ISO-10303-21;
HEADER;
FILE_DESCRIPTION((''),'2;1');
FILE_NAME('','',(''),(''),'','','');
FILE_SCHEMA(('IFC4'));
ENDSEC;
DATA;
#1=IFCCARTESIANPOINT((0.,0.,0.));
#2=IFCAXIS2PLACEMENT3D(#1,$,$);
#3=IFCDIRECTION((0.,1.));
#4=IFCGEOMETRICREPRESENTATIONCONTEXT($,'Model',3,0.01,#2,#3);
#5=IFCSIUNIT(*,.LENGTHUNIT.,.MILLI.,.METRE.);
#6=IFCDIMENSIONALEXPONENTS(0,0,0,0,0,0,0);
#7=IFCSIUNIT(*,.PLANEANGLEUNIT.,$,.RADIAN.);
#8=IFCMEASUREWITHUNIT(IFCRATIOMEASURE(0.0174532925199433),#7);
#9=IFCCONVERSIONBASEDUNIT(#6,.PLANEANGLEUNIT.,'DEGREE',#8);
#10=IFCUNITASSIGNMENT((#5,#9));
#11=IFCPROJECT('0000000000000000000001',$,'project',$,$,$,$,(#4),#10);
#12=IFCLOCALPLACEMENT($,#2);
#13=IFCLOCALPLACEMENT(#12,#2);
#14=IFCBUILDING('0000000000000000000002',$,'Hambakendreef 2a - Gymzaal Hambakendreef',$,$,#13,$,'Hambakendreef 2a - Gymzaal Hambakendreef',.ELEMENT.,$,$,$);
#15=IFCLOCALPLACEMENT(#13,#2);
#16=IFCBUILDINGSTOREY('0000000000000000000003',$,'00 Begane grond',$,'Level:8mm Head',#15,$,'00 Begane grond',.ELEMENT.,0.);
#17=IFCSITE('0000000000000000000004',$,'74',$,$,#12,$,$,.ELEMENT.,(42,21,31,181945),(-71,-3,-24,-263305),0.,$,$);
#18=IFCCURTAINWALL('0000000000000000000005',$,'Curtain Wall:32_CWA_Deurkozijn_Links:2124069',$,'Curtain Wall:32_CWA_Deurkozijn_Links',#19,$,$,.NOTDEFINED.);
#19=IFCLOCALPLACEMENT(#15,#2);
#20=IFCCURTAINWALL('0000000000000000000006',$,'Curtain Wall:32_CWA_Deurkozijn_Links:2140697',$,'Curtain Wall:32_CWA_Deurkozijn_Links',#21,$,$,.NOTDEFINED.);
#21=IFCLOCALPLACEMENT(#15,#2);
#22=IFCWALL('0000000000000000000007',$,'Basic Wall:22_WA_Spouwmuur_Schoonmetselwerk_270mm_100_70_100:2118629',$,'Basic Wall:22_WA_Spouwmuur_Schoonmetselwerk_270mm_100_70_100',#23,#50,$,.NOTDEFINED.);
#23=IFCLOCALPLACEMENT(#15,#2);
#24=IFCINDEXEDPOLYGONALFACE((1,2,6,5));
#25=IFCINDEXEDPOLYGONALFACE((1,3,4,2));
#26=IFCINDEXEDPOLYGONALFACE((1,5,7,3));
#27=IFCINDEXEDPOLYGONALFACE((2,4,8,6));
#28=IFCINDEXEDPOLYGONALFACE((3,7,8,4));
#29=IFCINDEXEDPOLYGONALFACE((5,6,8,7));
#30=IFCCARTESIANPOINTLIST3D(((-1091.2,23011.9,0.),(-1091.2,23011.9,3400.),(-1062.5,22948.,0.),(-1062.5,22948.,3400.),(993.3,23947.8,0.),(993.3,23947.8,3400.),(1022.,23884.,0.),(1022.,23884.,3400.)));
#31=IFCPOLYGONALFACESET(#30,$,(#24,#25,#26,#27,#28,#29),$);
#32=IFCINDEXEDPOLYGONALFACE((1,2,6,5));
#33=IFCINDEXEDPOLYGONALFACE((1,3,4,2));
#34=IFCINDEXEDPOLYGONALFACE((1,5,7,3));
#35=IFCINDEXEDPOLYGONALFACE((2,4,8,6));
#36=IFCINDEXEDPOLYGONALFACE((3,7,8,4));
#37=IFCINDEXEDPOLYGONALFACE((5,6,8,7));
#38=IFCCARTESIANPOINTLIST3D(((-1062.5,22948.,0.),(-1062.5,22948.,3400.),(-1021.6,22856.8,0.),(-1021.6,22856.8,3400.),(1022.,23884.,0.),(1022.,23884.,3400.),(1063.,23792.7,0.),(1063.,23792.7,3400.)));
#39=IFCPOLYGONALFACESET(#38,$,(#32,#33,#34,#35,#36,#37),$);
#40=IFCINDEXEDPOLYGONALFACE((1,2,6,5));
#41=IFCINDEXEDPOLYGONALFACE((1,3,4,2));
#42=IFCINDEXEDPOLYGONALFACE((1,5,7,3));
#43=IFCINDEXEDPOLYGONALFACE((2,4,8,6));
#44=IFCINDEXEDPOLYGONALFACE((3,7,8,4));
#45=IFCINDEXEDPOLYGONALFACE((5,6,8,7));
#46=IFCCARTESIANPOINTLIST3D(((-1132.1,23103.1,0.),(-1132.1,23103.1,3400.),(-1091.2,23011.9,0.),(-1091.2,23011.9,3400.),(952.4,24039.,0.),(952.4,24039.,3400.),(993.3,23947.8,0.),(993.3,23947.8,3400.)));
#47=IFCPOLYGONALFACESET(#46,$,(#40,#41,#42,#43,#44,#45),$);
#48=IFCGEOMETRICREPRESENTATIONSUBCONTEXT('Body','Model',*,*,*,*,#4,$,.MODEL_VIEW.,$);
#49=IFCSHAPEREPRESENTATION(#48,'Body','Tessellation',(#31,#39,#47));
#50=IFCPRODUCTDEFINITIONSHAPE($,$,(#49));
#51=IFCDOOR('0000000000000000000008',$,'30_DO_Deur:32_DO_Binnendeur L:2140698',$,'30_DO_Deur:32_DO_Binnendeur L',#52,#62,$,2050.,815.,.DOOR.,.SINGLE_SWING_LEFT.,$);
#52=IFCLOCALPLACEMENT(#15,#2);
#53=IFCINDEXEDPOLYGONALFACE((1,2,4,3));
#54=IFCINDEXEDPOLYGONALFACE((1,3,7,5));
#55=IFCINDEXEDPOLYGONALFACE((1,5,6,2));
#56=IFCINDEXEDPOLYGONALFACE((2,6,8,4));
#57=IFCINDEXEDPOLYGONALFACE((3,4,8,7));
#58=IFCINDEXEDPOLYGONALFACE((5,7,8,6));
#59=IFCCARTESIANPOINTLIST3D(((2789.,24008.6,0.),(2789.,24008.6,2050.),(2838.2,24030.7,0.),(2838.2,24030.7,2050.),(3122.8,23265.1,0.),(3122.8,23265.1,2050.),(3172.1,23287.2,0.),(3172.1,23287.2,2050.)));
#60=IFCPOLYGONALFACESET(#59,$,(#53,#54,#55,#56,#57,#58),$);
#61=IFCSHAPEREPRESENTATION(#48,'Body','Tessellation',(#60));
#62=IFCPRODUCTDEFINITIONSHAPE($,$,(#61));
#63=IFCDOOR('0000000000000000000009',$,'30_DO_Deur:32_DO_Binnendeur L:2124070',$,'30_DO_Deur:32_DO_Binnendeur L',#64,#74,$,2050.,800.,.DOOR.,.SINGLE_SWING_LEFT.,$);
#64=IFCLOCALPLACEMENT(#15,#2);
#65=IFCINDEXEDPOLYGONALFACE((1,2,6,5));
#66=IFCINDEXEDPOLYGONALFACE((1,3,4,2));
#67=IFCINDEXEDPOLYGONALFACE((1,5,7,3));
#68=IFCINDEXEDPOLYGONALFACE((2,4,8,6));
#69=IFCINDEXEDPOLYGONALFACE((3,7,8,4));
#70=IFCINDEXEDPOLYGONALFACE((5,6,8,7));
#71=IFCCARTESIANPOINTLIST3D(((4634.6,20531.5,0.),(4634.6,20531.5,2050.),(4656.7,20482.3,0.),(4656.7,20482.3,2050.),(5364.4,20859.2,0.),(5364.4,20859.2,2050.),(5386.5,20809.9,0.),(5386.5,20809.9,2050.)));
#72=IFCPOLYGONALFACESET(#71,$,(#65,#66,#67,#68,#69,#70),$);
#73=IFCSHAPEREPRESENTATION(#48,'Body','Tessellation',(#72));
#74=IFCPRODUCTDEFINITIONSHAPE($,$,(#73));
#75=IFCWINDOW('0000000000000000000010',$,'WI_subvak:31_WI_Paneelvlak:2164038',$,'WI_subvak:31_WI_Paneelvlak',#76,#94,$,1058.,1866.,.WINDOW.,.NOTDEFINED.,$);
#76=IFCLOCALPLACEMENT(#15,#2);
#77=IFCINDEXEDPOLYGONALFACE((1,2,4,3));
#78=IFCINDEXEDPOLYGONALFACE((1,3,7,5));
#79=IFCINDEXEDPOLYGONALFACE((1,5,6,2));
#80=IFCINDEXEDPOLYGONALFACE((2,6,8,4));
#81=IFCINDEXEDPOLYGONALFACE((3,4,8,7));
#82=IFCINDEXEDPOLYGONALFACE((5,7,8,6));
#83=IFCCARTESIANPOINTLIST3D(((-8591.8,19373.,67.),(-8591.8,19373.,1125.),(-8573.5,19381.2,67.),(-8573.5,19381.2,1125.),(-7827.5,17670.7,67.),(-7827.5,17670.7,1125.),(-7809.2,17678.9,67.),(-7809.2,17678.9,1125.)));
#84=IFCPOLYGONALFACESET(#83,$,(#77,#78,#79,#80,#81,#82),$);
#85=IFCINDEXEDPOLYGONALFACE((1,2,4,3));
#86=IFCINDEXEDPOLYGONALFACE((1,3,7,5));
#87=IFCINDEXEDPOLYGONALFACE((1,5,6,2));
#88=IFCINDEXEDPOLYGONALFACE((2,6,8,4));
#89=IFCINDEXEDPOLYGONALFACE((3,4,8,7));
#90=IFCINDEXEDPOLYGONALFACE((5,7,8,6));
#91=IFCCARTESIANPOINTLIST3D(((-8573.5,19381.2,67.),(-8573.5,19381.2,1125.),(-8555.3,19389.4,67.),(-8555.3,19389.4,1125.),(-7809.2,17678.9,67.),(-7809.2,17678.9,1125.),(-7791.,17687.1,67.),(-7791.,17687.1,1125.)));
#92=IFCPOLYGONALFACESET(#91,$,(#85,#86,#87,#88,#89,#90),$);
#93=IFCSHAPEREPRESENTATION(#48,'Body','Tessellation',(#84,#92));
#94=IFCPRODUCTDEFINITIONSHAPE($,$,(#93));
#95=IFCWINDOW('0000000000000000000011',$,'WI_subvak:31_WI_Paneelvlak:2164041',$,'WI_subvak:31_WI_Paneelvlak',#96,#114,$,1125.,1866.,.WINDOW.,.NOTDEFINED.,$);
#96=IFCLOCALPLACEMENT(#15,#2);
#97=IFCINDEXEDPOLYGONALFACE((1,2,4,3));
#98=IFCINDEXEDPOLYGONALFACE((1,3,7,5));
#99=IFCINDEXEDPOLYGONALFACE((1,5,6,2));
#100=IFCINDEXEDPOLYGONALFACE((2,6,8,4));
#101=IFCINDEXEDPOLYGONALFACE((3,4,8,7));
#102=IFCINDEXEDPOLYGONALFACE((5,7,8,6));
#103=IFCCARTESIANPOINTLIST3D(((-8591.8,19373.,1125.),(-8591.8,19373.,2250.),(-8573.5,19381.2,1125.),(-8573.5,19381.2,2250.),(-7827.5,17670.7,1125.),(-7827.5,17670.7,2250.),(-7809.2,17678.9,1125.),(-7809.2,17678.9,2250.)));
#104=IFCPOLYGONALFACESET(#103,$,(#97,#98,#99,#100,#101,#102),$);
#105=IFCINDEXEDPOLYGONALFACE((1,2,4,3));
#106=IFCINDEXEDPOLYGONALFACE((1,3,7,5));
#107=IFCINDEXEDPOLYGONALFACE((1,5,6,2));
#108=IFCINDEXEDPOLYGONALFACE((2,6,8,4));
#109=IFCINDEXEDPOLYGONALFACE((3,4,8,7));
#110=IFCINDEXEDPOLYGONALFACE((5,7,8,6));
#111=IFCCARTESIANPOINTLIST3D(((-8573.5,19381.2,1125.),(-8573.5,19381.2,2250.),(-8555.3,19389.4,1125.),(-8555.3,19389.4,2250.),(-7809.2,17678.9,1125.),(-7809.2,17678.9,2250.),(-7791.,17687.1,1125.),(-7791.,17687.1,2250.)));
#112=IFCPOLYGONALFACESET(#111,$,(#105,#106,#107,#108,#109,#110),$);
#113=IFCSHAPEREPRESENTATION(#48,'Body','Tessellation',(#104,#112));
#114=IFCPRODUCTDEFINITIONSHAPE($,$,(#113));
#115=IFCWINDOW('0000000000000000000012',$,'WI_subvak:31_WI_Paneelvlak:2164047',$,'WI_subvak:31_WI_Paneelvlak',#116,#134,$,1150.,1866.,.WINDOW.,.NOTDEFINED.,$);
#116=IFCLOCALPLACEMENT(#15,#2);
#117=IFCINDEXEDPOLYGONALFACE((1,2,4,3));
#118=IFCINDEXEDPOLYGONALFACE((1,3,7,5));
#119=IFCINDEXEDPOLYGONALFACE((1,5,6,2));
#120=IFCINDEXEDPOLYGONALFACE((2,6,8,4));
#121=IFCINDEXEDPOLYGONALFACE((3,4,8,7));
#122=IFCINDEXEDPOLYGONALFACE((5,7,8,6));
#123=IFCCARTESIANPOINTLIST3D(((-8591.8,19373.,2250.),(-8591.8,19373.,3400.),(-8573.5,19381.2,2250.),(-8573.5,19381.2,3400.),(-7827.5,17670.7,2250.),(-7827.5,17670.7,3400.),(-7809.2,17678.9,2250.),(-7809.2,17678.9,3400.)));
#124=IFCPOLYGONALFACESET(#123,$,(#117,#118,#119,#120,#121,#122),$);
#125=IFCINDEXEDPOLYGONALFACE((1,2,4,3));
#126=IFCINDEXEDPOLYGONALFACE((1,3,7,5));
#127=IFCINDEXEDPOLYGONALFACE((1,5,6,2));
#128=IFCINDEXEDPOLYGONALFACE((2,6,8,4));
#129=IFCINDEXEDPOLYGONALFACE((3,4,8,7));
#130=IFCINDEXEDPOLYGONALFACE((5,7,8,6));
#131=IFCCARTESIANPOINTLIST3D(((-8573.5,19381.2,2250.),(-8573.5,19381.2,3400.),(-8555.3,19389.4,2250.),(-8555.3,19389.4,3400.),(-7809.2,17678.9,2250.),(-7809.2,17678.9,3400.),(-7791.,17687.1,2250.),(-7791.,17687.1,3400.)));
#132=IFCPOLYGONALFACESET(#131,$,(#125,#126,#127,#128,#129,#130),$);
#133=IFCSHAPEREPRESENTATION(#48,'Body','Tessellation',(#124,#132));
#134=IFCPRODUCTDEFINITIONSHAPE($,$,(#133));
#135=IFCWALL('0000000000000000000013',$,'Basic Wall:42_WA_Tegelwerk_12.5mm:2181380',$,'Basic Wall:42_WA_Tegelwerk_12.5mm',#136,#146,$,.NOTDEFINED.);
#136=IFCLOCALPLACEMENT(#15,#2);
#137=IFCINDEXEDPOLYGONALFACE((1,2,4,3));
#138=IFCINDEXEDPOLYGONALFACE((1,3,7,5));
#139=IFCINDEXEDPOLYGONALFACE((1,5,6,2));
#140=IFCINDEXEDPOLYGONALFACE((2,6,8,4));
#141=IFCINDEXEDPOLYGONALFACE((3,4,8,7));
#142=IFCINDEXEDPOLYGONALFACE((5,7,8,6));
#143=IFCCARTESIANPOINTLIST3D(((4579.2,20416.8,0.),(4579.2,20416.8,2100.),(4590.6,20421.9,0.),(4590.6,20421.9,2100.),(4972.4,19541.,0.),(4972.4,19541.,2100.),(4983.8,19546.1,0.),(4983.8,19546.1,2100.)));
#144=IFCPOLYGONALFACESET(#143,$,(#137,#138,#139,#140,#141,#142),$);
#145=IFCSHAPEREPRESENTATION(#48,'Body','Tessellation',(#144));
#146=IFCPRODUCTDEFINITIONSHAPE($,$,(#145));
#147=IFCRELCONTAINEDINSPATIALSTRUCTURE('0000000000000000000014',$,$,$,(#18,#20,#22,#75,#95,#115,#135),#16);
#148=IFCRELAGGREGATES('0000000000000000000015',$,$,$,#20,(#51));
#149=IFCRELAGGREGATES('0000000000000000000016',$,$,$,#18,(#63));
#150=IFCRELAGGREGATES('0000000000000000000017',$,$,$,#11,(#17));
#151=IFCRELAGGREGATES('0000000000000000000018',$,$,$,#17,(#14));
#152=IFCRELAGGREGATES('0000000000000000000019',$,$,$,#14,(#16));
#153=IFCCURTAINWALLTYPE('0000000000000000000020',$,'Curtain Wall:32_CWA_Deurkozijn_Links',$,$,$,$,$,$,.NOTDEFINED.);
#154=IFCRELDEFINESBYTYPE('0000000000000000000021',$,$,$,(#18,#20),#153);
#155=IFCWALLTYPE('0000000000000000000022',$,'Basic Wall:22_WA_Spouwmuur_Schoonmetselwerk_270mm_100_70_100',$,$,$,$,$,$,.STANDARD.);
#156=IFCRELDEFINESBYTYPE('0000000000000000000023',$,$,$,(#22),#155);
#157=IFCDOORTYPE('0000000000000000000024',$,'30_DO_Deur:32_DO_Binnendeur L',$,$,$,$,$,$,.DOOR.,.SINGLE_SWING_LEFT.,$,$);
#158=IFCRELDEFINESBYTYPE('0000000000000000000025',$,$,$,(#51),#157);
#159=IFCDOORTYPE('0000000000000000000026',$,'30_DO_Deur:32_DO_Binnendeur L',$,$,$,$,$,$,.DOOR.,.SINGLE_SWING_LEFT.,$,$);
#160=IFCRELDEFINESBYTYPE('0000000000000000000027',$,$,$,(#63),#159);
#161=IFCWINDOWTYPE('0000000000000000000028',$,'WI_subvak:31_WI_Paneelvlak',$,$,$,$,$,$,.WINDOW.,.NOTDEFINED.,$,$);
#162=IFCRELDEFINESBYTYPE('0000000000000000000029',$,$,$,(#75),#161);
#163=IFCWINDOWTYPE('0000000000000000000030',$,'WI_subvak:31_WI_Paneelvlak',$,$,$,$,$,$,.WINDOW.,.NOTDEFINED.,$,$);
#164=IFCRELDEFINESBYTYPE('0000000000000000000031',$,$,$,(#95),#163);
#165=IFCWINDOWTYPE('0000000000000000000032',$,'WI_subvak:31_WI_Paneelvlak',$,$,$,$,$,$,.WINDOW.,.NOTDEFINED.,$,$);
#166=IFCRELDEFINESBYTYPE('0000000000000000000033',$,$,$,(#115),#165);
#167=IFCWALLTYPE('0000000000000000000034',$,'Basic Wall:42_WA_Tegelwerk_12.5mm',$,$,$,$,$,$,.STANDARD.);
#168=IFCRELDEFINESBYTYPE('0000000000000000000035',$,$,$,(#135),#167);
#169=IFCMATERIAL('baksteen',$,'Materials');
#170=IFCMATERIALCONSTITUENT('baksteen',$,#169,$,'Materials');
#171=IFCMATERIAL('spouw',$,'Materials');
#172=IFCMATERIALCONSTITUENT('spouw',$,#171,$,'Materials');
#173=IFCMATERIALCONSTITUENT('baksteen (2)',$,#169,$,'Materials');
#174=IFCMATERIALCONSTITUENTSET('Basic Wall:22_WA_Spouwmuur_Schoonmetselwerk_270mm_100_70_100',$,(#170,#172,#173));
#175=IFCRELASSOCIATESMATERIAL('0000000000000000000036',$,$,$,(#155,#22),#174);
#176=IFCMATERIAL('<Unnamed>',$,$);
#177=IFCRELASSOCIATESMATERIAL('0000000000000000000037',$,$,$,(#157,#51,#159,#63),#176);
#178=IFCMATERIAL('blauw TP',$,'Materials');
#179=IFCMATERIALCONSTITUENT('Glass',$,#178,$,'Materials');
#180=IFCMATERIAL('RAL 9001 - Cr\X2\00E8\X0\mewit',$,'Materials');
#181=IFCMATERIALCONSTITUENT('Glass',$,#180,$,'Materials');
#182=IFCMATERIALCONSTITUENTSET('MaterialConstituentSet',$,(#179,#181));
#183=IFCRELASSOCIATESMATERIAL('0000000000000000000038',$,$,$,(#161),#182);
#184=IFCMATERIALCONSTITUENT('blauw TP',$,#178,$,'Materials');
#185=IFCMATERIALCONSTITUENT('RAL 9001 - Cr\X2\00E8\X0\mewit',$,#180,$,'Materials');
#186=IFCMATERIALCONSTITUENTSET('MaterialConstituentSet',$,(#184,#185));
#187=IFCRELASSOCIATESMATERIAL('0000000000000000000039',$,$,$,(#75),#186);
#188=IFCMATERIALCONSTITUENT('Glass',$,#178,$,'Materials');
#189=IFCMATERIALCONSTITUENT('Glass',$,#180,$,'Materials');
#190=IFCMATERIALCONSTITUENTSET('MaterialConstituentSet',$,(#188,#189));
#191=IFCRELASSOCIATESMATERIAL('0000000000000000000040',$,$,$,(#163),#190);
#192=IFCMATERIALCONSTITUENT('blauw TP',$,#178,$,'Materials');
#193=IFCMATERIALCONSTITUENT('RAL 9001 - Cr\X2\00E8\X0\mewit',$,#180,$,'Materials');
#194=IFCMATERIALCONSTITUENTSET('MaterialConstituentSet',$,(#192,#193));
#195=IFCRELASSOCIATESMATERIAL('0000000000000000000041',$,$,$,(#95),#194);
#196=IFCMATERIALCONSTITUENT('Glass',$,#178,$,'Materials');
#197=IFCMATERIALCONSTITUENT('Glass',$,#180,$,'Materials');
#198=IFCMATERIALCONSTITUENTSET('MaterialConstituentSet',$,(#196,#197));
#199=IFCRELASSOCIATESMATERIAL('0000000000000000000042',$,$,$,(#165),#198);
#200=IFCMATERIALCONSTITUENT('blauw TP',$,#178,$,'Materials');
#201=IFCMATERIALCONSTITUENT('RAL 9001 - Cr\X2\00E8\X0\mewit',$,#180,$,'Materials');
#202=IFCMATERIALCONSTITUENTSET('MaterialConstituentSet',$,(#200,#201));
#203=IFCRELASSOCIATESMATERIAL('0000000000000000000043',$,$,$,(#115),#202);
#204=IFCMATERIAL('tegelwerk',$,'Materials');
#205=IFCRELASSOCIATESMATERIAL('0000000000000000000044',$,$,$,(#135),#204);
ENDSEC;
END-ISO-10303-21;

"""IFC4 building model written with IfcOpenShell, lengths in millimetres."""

from ifc_helpers import new_model, entity, si_unit, converted_unit, direction, frame, origin, place, context, subcontext, project, spatial, indexed_curve, outline, extrude, source, transform, mapped, material, constituent, constituent_set, type_object, type_shapes, element, aggregate, save


model = new_model("IFC4")

# Units and contexts
model_context = context("Model", 3, precision=0.01, world=origin(), true_north=direction((0.0, 1.0)))
body_context = subcontext(model_context, "Body", "Model", "MODEL_VIEW")
ifc_project = project(units=[si_unit("LENGTHUNIT", "METRE", prefix="MILLI"), converted_unit("PLANEANGLEUNIT", "DEGREE", entity("IfcRatioMeasure", 0.0174532925199433), si_unit("PLANEANGLEUNIT", "RADIAN"), dimensions=[0, 0, 0, 0, 0, 0, 0])], contexts=[model_context])

# Site, building, storey
site_placement = place(None, origin())
site = spatial("IfcSite", under=ifc_project, at=site_placement, Name="74", CompositionType="ELEMENT", RefLatitude=(42, 21, 31, 181945), RefLongitude=(-71, -3, -24, -263305), RefElevation=0.0)
building_placement = place(site_placement, origin())
building = spatial("IfcBuilding", under=site, at=building_placement, Name="Hambakendreef 2a - Gymzaal Hambakendreef", LongName="Hambakendreef 2a - Gymzaal Hambakendreef", CompositionType="ELEMENT")
storey_placement = place(building_placement, origin())
storey = spatial("IfcBuildingStorey", under=building, at=storey_placement, Name="00 Begane grond", ObjectType="Level:8mm Head", LongName="00 Begane grond", CompositionType="ELEMENT", Elevation=0.0)

# Shared definitions
ifc_material_1 = material(Name="<Unnamed>")

# Curtain walls
curtain_wall_type_1 = type_object("IfcCurtainWallType", Name="Curtain Wall:32_CWA_Deurkozijn_Links", PredefinedType="NOTDEFINED")
curtain_wall_1_placement = place(storey_placement, origin())
curtain_wall_1 = element("IfcCurtainWall", 1, at=curtain_wall_1_placement, inside=storey, type_object=curtain_wall_type_1, Name="Curtain Wall:32_CWA_Deurkozijn_Links:2124069", ObjectType="Curtain Wall:32_CWA_Deurkozijn_Links", PredefinedType="NOTDEFINED")
curtain_wall_2_placement = place(storey_placement, origin())
curtain_wall_2 = element("IfcCurtainWall", 2, at=curtain_wall_2_placement, inside=storey, type_object=curtain_wall_type_1, Name="Curtain Wall:32_CWA_Deurkozijn_Links:2140697", ObjectType="Curtain Wall:32_CWA_Deurkozijn_Links", PredefinedType="NOTDEFINED")

# Shared definitions
ifc_material_2 = material(Name="baksteen", Category="Materials")
ifc_material_3 = material(Name="spouw", Category="Materials")

# Wall, opening
ifc_constituent_1 = constituent(ifc_material_2, Name="baksteen", Category="Materials")
ifc_constituent_2 = constituent(ifc_material_3, Name="spouw", Category="Materials")
ifc_constituent_3 = constituent(ifc_material_2, Name="baksteen (2)", Category="Materials")
ifc_constituent_set_1 = constituent_set(constituents=[ifc_constituent_1, ifc_constituent_2, ifc_constituent_3], Name="Basic Wall:22_WA_Spouwmuur_Schoonmetselwerk_270mm_100_70_100")
wall_type_1 = type_object("IfcWallType", Name="Basic Wall:22_WA_Spouwmuur_Schoonmetselwerk_270mm_100_70_100", PredefinedType="STANDARD", material=ifc_constituent_set_1)
wall_1_placement = place(storey_placement, frame((-1076.9, 22980.0, 0.0), z_axis=(0.0, 0.0, 1.0), x_axis=(0.91227, 0.40959, 0.0)))
wall_1 = element("IfcWall", 3, at=wall_1_placement, inside=storey, type_object=wall_type_1, material=ifc_constituent_set_1, Name="Basic Wall:22_WA_Spouwmuur_Schoonmetselwerk_270mm_100_70_100:2118629", ObjectType="Basic Wall:22_WA_Spouwmuur_Schoonmetselwerk_270mm_100_70_100", PredefinedType="NOTDEFINED", context=body_context, shape_type="SweptSolid", body=[
    extrude(outline(indexed_curve([(-1142.5, -35.0), (1142.5, -35.0), (1142.5, 35.0), (-1142.5, 35.0), (-1142.5, -35.0)], self_intersect=False)), frame((1142.5, 0.0, 0.0)), (0.0, 0.0, 1.0), 3400.0),
    extrude(outline(indexed_curve([(-50.0, -1142.5), (50.0, -1142.5), (50.0, 1142.5), (-50.0, 1142.5), (-50.0, -1142.5)], self_intersect=False)), frame((1142.5, -85.0, 0.0), z_axis=(0.0, 0.0, 1.0), x_axis=(0.0, 1.0, 0.0)), (0.0, 0.0, 1.0), 3400.0),
    extrude(outline(indexed_curve([(-50.0, -1142.5), (50.0, -1142.5), (50.0, 1142.5), (-50.0, 1142.5), (-50.0, -1142.5)], self_intersect=False)), frame((1142.5, 85.0, 0.0), z_axis=(0.0, 0.0, 1.0), x_axis=(0.0, -1.0, 0.0)), (0.0, 0.0, 1.0), 3400.0),
])
opening_1_placement = place(wall_1_placement, origin())
element("IfcOpeningElement", 4, at=opening_1_placement, cuts=wall_1, PredefinedType="OPENING", context=body_context, shape_type="SweptSolid", body=[
    extrude(outline(indexed_curve([(-1050.0, -457.5), (1050.0, -457.5), (1050.0, 457.5), (-1050.0, 457.5), (-1050.0, -457.5)], self_intersect=False)), frame((2980.8, -287.4, 1050.0), z_axis=(0.0, 1.0, 0.0), x_axis=(0.0, 0.0, 1.0)), (0.0, 0.0, 1.0), 574.8),
])

# Doors
door_type_1 = type_object("IfcDoorType", Name="30_DO_Deur:32_DO_Binnendeur L", OperationType="SINGLE_SWING_LEFT", PredefinedType="DOOR", material=ifc_material_1)
shared_shape_1 = source(origin(), body_context, "Body", "SweptSolid", [
    extrude(outline(indexed_curve([(-27.0, -407.5), (27.0, -407.5), (27.0, 407.5), (-27.0, 407.5), (-27.0, -407.5)], self_intersect=False)), frame((0.0, 0.0, 0.0), z_axis=(0.0, 0.0, 1.0), x_axis=(0.0, 1.0, 0.0)), (0.0, 0.0, 1.0), 2050.0),
])
type_shapes(door_type_1, [shared_shape_1])
door_1_placement = place(curtain_wall_2_placement, frame((2980.5, 23647.9, 0.0), z_axis=(0.0, 0.0, 1.0), x_axis=(0.40959, -0.91227, 0.0)))
door_1 = element("IfcDoor", 5, at=door_1_placement, type_object=door_type_1, material=ifc_material_1, Name="30_DO_Deur:32_DO_Binnendeur L:2140698", ObjectType="30_DO_Deur:32_DO_Binnendeur L", OperationType="SINGLE_SWING_LEFT", OverallHeight=2050.0, OverallWidth=815.0, PredefinedType="DOOR", context=body_context, shape_type="MappedRepresentation", body=[
    mapped(shared_shape_1, transform((0.0, 0.0, 0.0), scale=1.0)),
])
aggregate(curtain_wall_2, [door_1])
door_type_2 = type_object("IfcDoorType", Name="30_DO_Deur:32_DO_Binnendeur L", OperationType="SINGLE_SWING_LEFT", PredefinedType="DOOR", material=ifc_material_1)
shared_shape_2 = source(origin(), body_context, "Body", "SweptSolid", [
    extrude(outline(indexed_curve([(-27.0, -400.0), (27.0, -400.0), (27.0, 400.0), (-27.0, 400.0), (-27.0, -400.0)], self_intersect=False)), frame((0.0, 0.0, 0.0), z_axis=(0.0, 0.0, 1.0), x_axis=(0.0, 1.0, 0.0)), (0.0, 0.0, 1.0), 2050.0),
])
type_shapes(door_type_2, [shared_shape_2])
door_2_placement = place(curtain_wall_1_placement, frame((5010.5, 20670.7, 0.0), z_axis=(0.0, 0.0, 1.0), x_axis=(0.91227, 0.40959, 0.0)))
door_2 = element("IfcDoor", 6, at=door_2_placement, type_object=door_type_2, material=ifc_material_1, Name="30_DO_Deur:32_DO_Binnendeur L:2124070", ObjectType="30_DO_Deur:32_DO_Binnendeur L", OperationType="SINGLE_SWING_LEFT", OverallHeight=2050.0, OverallWidth=800.0, PredefinedType="DOOR", context=body_context, shape_type="MappedRepresentation", body=[
    mapped(shared_shape_2, transform((0.0, 0.0, 0.0), scale=1.0)),
])
aggregate(curtain_wall_1, [door_2])

# Windows
ifc_material_4 = material(Name="blauw TP", Category="Materials")
ifc_constituent_4 = constituent(ifc_material_4, Name="blauw TP", Category="Materials")
ifc_material_5 = material(Name="RAL 9001 - Crèmewit", Category="Materials")
ifc_constituent_5 = constituent(ifc_material_5, Name="RAL 9001 - Crèmewit", Category="Materials")
ifc_constituent_set_2 = constituent_set(constituents=[ifc_constituent_4, ifc_constituent_5], Name="MaterialConstituentSet")
ifc_constituent_6 = constituent(ifc_material_4, Name="Glass", Category="Materials")
ifc_constituent_7 = constituent(ifc_material_5, Name="Glass", Category="Materials")
ifc_constituent_set_3 = constituent_set(constituents=[ifc_constituent_6, ifc_constituent_7], Name="MaterialConstituentSet")
window_type_1 = type_object("IfcWindowType", Name="WI_subvak:31_WI_Paneelvlak", PartitioningType="NOTDEFINED", PredefinedType="WINDOW", material=ifc_constituent_set_3)
shared_shape_3 = source(origin(), body_context, "Body", "SweptSolid", [
    extrude(outline(indexed_curve([(-10.0, -933.0), (10.0, -933.0), (10.0, 933.0), (-10.0, 933.0), (-10.0, -933.0)], self_intersect=False)), frame((0.0, 10.0, 0.0), z_axis=(0.0, 0.0, 1.0), x_axis=(0.0, -1.0, 0.0)), (0.0, 0.0, 1.0), 1058.0),
    extrude(outline(indexed_curve([(-10.0, -933.0), (10.0, -933.0), (10.0, 933.0), (-10.0, 933.0), (-10.0, -933.0)], self_intersect=False)), frame((0.0, -10.0, 0.0), z_axis=(0.0, 0.0, 1.0), x_axis=(0.0, -1.0, 0.0)), (0.0, 0.0, 1.0), 1058.0),
])
type_shapes(window_type_1, [shared_shape_3])
window_1_placement = place(storey_placement, frame((-8191.4, 18530.0, 67.0), z_axis=(0.0, 0.0, 1.0), x_axis=(-0.40959, 0.91227, 0.0)))
element("IfcWindow", 7, at=window_1_placement, inside=storey, type_object=window_type_1, material=ifc_constituent_set_2, Name="WI_subvak:31_WI_Paneelvlak:2164038", ObjectType="WI_subvak:31_WI_Paneelvlak", OverallHeight=1058.0, OverallWidth=1866.0, PartitioningType="NOTDEFINED", PredefinedType="WINDOW", context=body_context, shape_type="MappedRepresentation", body=[
    mapped(shared_shape_3, transform((0.0, 0.0, 0.0), scale=1.0)),
])
ifc_constituent_8 = constituent(ifc_material_4, Name="blauw TP", Category="Materials")
ifc_constituent_9 = constituent(ifc_material_5, Name="RAL 9001 - Crèmewit", Category="Materials")
ifc_constituent_set_4 = constituent_set(constituents=[ifc_constituent_8, ifc_constituent_9], Name="MaterialConstituentSet")
ifc_constituent_10 = constituent(ifc_material_4, Name="Glass", Category="Materials")
ifc_constituent_11 = constituent(ifc_material_5, Name="Glass", Category="Materials")
ifc_constituent_set_5 = constituent_set(constituents=[ifc_constituent_10, ifc_constituent_11], Name="MaterialConstituentSet")
window_type_2 = type_object("IfcWindowType", Name="WI_subvak:31_WI_Paneelvlak", PartitioningType="NOTDEFINED", PredefinedType="WINDOW", material=ifc_constituent_set_5)
shared_shape_4 = source(origin(), body_context, "Body", "SweptSolid", [
    extrude(outline(indexed_curve([(-10.0, -933.0), (10.0, -933.0), (10.0, 933.0), (-10.0, 933.0), (-10.0, -933.0)], self_intersect=False)), frame((0.0, 10.0, 0.0), z_axis=(0.0, 0.0, 1.0), x_axis=(0.0, -1.0, 0.0)), (0.0, 0.0, 1.0), 1125.0),
    extrude(outline(indexed_curve([(-10.0, -933.0), (10.0, -933.0), (10.0, 933.0), (-10.0, 933.0), (-10.0, -933.0)], self_intersect=False)), frame((0.0, -10.0, 0.0), z_axis=(0.0, 0.0, 1.0), x_axis=(0.0, -1.0, 0.0)), (0.0, 0.0, 1.0), 1125.0),
])
type_shapes(window_type_2, [shared_shape_4])
window_2_placement = place(storey_placement, frame((-8191.4, 18530.0, 1125.0), z_axis=(0.0, 0.0, 1.0), x_axis=(-0.40959, 0.91227, 0.0)))
element("IfcWindow", 8, at=window_2_placement, inside=storey, type_object=window_type_2, material=ifc_constituent_set_4, Name="WI_subvak:31_WI_Paneelvlak:2164041", ObjectType="WI_subvak:31_WI_Paneelvlak", OverallHeight=1125.0, OverallWidth=1866.0, PartitioningType="NOTDEFINED", PredefinedType="WINDOW", context=body_context, shape_type="MappedRepresentation", body=[
    mapped(shared_shape_4, transform((0.0, 0.0, 0.0), scale=1.0)),
])
ifc_constituent_12 = constituent(ifc_material_4, Name="blauw TP", Category="Materials")
ifc_constituent_13 = constituent(ifc_material_5, Name="RAL 9001 - Crèmewit", Category="Materials")
ifc_constituent_set_6 = constituent_set(constituents=[ifc_constituent_12, ifc_constituent_13], Name="MaterialConstituentSet")
ifc_constituent_14 = constituent(ifc_material_4, Name="Glass", Category="Materials")
ifc_constituent_15 = constituent(ifc_material_5, Name="Glass", Category="Materials")
ifc_constituent_set_7 = constituent_set(constituents=[ifc_constituent_14, ifc_constituent_15], Name="MaterialConstituentSet")
window_type_3 = type_object("IfcWindowType", Name="WI_subvak:31_WI_Paneelvlak", PartitioningType="NOTDEFINED", PredefinedType="WINDOW", material=ifc_constituent_set_7)
shared_shape_5 = source(origin(), body_context, "Body", "SweptSolid", [
    extrude(outline(indexed_curve([(-10.0, -933.0), (10.0, -933.0), (10.0, 933.0), (-10.0, 933.0), (-10.0, -933.0)], self_intersect=False)), frame((0.0, 10.0, 0.0), z_axis=(0.0, 0.0, 1.0), x_axis=(0.0, -1.0, 0.0)), (0.0, 0.0, 1.0), 1150.0),
    extrude(outline(indexed_curve([(-10.0, -933.0), (10.0, -933.0), (10.0, 933.0), (-10.0, 933.0), (-10.0, -933.0)], self_intersect=False)), frame((0.0, -10.0, 0.0), z_axis=(0.0, 0.0, 1.0), x_axis=(0.0, -1.0, 0.0)), (0.0, 0.0, 1.0), 1150.0),
])
type_shapes(window_type_3, [shared_shape_5])
window_3_placement = place(storey_placement, frame((-8191.4, 18530.0, 2250.0), z_axis=(0.0, 0.0, 1.0), x_axis=(-0.40959, 0.91227, 0.0)))
element("IfcWindow", 9, at=window_3_placement, inside=storey, type_object=window_type_3, material=ifc_constituent_set_6, Name="WI_subvak:31_WI_Paneelvlak:2164047", ObjectType="WI_subvak:31_WI_Paneelvlak", OverallHeight=1150.0, OverallWidth=1866.0, PartitioningType="NOTDEFINED", PredefinedType="WINDOW", context=body_context, shape_type="MappedRepresentation", body=[
    mapped(shared_shape_5, transform((0.0, 0.0, 0.0), scale=1.0)),
])

# Wall
ifc_material_6 = material(Name="tegelwerk", Category="Materials")
wall_type_2 = type_object("IfcWallType", Name="Basic Wall:42_WA_Tegelwerk_12.5mm", PredefinedType="STANDARD")
wall_2_placement = place(storey_placement, frame((4584.9, 20419.3, 0.0), z_axis=(0.0, 0.0, 1.0), x_axis=(0.40959, -0.91227, 0.0)))
element("IfcWall", 10, at=wall_2_placement, inside=storey, type_object=wall_type_2, material=ifc_material_6, Name="Basic Wall:42_WA_Tegelwerk_12.5mm:2181380", ObjectType="Basic Wall:42_WA_Tegelwerk_12.5mm", PredefinedType="NOTDEFINED", context=body_context, shape_type="SweptSolid", body=[
    extrude(outline(indexed_curve([(960.0, 6.2), (0.0, 6.2), (0.0, -6.2), (960.0, -6.3), (960.0, 6.2)], self_intersect=False)), origin(), (0.0, 0.0, 1.0), 2100.0),
])

save(model, "model.ifc")
